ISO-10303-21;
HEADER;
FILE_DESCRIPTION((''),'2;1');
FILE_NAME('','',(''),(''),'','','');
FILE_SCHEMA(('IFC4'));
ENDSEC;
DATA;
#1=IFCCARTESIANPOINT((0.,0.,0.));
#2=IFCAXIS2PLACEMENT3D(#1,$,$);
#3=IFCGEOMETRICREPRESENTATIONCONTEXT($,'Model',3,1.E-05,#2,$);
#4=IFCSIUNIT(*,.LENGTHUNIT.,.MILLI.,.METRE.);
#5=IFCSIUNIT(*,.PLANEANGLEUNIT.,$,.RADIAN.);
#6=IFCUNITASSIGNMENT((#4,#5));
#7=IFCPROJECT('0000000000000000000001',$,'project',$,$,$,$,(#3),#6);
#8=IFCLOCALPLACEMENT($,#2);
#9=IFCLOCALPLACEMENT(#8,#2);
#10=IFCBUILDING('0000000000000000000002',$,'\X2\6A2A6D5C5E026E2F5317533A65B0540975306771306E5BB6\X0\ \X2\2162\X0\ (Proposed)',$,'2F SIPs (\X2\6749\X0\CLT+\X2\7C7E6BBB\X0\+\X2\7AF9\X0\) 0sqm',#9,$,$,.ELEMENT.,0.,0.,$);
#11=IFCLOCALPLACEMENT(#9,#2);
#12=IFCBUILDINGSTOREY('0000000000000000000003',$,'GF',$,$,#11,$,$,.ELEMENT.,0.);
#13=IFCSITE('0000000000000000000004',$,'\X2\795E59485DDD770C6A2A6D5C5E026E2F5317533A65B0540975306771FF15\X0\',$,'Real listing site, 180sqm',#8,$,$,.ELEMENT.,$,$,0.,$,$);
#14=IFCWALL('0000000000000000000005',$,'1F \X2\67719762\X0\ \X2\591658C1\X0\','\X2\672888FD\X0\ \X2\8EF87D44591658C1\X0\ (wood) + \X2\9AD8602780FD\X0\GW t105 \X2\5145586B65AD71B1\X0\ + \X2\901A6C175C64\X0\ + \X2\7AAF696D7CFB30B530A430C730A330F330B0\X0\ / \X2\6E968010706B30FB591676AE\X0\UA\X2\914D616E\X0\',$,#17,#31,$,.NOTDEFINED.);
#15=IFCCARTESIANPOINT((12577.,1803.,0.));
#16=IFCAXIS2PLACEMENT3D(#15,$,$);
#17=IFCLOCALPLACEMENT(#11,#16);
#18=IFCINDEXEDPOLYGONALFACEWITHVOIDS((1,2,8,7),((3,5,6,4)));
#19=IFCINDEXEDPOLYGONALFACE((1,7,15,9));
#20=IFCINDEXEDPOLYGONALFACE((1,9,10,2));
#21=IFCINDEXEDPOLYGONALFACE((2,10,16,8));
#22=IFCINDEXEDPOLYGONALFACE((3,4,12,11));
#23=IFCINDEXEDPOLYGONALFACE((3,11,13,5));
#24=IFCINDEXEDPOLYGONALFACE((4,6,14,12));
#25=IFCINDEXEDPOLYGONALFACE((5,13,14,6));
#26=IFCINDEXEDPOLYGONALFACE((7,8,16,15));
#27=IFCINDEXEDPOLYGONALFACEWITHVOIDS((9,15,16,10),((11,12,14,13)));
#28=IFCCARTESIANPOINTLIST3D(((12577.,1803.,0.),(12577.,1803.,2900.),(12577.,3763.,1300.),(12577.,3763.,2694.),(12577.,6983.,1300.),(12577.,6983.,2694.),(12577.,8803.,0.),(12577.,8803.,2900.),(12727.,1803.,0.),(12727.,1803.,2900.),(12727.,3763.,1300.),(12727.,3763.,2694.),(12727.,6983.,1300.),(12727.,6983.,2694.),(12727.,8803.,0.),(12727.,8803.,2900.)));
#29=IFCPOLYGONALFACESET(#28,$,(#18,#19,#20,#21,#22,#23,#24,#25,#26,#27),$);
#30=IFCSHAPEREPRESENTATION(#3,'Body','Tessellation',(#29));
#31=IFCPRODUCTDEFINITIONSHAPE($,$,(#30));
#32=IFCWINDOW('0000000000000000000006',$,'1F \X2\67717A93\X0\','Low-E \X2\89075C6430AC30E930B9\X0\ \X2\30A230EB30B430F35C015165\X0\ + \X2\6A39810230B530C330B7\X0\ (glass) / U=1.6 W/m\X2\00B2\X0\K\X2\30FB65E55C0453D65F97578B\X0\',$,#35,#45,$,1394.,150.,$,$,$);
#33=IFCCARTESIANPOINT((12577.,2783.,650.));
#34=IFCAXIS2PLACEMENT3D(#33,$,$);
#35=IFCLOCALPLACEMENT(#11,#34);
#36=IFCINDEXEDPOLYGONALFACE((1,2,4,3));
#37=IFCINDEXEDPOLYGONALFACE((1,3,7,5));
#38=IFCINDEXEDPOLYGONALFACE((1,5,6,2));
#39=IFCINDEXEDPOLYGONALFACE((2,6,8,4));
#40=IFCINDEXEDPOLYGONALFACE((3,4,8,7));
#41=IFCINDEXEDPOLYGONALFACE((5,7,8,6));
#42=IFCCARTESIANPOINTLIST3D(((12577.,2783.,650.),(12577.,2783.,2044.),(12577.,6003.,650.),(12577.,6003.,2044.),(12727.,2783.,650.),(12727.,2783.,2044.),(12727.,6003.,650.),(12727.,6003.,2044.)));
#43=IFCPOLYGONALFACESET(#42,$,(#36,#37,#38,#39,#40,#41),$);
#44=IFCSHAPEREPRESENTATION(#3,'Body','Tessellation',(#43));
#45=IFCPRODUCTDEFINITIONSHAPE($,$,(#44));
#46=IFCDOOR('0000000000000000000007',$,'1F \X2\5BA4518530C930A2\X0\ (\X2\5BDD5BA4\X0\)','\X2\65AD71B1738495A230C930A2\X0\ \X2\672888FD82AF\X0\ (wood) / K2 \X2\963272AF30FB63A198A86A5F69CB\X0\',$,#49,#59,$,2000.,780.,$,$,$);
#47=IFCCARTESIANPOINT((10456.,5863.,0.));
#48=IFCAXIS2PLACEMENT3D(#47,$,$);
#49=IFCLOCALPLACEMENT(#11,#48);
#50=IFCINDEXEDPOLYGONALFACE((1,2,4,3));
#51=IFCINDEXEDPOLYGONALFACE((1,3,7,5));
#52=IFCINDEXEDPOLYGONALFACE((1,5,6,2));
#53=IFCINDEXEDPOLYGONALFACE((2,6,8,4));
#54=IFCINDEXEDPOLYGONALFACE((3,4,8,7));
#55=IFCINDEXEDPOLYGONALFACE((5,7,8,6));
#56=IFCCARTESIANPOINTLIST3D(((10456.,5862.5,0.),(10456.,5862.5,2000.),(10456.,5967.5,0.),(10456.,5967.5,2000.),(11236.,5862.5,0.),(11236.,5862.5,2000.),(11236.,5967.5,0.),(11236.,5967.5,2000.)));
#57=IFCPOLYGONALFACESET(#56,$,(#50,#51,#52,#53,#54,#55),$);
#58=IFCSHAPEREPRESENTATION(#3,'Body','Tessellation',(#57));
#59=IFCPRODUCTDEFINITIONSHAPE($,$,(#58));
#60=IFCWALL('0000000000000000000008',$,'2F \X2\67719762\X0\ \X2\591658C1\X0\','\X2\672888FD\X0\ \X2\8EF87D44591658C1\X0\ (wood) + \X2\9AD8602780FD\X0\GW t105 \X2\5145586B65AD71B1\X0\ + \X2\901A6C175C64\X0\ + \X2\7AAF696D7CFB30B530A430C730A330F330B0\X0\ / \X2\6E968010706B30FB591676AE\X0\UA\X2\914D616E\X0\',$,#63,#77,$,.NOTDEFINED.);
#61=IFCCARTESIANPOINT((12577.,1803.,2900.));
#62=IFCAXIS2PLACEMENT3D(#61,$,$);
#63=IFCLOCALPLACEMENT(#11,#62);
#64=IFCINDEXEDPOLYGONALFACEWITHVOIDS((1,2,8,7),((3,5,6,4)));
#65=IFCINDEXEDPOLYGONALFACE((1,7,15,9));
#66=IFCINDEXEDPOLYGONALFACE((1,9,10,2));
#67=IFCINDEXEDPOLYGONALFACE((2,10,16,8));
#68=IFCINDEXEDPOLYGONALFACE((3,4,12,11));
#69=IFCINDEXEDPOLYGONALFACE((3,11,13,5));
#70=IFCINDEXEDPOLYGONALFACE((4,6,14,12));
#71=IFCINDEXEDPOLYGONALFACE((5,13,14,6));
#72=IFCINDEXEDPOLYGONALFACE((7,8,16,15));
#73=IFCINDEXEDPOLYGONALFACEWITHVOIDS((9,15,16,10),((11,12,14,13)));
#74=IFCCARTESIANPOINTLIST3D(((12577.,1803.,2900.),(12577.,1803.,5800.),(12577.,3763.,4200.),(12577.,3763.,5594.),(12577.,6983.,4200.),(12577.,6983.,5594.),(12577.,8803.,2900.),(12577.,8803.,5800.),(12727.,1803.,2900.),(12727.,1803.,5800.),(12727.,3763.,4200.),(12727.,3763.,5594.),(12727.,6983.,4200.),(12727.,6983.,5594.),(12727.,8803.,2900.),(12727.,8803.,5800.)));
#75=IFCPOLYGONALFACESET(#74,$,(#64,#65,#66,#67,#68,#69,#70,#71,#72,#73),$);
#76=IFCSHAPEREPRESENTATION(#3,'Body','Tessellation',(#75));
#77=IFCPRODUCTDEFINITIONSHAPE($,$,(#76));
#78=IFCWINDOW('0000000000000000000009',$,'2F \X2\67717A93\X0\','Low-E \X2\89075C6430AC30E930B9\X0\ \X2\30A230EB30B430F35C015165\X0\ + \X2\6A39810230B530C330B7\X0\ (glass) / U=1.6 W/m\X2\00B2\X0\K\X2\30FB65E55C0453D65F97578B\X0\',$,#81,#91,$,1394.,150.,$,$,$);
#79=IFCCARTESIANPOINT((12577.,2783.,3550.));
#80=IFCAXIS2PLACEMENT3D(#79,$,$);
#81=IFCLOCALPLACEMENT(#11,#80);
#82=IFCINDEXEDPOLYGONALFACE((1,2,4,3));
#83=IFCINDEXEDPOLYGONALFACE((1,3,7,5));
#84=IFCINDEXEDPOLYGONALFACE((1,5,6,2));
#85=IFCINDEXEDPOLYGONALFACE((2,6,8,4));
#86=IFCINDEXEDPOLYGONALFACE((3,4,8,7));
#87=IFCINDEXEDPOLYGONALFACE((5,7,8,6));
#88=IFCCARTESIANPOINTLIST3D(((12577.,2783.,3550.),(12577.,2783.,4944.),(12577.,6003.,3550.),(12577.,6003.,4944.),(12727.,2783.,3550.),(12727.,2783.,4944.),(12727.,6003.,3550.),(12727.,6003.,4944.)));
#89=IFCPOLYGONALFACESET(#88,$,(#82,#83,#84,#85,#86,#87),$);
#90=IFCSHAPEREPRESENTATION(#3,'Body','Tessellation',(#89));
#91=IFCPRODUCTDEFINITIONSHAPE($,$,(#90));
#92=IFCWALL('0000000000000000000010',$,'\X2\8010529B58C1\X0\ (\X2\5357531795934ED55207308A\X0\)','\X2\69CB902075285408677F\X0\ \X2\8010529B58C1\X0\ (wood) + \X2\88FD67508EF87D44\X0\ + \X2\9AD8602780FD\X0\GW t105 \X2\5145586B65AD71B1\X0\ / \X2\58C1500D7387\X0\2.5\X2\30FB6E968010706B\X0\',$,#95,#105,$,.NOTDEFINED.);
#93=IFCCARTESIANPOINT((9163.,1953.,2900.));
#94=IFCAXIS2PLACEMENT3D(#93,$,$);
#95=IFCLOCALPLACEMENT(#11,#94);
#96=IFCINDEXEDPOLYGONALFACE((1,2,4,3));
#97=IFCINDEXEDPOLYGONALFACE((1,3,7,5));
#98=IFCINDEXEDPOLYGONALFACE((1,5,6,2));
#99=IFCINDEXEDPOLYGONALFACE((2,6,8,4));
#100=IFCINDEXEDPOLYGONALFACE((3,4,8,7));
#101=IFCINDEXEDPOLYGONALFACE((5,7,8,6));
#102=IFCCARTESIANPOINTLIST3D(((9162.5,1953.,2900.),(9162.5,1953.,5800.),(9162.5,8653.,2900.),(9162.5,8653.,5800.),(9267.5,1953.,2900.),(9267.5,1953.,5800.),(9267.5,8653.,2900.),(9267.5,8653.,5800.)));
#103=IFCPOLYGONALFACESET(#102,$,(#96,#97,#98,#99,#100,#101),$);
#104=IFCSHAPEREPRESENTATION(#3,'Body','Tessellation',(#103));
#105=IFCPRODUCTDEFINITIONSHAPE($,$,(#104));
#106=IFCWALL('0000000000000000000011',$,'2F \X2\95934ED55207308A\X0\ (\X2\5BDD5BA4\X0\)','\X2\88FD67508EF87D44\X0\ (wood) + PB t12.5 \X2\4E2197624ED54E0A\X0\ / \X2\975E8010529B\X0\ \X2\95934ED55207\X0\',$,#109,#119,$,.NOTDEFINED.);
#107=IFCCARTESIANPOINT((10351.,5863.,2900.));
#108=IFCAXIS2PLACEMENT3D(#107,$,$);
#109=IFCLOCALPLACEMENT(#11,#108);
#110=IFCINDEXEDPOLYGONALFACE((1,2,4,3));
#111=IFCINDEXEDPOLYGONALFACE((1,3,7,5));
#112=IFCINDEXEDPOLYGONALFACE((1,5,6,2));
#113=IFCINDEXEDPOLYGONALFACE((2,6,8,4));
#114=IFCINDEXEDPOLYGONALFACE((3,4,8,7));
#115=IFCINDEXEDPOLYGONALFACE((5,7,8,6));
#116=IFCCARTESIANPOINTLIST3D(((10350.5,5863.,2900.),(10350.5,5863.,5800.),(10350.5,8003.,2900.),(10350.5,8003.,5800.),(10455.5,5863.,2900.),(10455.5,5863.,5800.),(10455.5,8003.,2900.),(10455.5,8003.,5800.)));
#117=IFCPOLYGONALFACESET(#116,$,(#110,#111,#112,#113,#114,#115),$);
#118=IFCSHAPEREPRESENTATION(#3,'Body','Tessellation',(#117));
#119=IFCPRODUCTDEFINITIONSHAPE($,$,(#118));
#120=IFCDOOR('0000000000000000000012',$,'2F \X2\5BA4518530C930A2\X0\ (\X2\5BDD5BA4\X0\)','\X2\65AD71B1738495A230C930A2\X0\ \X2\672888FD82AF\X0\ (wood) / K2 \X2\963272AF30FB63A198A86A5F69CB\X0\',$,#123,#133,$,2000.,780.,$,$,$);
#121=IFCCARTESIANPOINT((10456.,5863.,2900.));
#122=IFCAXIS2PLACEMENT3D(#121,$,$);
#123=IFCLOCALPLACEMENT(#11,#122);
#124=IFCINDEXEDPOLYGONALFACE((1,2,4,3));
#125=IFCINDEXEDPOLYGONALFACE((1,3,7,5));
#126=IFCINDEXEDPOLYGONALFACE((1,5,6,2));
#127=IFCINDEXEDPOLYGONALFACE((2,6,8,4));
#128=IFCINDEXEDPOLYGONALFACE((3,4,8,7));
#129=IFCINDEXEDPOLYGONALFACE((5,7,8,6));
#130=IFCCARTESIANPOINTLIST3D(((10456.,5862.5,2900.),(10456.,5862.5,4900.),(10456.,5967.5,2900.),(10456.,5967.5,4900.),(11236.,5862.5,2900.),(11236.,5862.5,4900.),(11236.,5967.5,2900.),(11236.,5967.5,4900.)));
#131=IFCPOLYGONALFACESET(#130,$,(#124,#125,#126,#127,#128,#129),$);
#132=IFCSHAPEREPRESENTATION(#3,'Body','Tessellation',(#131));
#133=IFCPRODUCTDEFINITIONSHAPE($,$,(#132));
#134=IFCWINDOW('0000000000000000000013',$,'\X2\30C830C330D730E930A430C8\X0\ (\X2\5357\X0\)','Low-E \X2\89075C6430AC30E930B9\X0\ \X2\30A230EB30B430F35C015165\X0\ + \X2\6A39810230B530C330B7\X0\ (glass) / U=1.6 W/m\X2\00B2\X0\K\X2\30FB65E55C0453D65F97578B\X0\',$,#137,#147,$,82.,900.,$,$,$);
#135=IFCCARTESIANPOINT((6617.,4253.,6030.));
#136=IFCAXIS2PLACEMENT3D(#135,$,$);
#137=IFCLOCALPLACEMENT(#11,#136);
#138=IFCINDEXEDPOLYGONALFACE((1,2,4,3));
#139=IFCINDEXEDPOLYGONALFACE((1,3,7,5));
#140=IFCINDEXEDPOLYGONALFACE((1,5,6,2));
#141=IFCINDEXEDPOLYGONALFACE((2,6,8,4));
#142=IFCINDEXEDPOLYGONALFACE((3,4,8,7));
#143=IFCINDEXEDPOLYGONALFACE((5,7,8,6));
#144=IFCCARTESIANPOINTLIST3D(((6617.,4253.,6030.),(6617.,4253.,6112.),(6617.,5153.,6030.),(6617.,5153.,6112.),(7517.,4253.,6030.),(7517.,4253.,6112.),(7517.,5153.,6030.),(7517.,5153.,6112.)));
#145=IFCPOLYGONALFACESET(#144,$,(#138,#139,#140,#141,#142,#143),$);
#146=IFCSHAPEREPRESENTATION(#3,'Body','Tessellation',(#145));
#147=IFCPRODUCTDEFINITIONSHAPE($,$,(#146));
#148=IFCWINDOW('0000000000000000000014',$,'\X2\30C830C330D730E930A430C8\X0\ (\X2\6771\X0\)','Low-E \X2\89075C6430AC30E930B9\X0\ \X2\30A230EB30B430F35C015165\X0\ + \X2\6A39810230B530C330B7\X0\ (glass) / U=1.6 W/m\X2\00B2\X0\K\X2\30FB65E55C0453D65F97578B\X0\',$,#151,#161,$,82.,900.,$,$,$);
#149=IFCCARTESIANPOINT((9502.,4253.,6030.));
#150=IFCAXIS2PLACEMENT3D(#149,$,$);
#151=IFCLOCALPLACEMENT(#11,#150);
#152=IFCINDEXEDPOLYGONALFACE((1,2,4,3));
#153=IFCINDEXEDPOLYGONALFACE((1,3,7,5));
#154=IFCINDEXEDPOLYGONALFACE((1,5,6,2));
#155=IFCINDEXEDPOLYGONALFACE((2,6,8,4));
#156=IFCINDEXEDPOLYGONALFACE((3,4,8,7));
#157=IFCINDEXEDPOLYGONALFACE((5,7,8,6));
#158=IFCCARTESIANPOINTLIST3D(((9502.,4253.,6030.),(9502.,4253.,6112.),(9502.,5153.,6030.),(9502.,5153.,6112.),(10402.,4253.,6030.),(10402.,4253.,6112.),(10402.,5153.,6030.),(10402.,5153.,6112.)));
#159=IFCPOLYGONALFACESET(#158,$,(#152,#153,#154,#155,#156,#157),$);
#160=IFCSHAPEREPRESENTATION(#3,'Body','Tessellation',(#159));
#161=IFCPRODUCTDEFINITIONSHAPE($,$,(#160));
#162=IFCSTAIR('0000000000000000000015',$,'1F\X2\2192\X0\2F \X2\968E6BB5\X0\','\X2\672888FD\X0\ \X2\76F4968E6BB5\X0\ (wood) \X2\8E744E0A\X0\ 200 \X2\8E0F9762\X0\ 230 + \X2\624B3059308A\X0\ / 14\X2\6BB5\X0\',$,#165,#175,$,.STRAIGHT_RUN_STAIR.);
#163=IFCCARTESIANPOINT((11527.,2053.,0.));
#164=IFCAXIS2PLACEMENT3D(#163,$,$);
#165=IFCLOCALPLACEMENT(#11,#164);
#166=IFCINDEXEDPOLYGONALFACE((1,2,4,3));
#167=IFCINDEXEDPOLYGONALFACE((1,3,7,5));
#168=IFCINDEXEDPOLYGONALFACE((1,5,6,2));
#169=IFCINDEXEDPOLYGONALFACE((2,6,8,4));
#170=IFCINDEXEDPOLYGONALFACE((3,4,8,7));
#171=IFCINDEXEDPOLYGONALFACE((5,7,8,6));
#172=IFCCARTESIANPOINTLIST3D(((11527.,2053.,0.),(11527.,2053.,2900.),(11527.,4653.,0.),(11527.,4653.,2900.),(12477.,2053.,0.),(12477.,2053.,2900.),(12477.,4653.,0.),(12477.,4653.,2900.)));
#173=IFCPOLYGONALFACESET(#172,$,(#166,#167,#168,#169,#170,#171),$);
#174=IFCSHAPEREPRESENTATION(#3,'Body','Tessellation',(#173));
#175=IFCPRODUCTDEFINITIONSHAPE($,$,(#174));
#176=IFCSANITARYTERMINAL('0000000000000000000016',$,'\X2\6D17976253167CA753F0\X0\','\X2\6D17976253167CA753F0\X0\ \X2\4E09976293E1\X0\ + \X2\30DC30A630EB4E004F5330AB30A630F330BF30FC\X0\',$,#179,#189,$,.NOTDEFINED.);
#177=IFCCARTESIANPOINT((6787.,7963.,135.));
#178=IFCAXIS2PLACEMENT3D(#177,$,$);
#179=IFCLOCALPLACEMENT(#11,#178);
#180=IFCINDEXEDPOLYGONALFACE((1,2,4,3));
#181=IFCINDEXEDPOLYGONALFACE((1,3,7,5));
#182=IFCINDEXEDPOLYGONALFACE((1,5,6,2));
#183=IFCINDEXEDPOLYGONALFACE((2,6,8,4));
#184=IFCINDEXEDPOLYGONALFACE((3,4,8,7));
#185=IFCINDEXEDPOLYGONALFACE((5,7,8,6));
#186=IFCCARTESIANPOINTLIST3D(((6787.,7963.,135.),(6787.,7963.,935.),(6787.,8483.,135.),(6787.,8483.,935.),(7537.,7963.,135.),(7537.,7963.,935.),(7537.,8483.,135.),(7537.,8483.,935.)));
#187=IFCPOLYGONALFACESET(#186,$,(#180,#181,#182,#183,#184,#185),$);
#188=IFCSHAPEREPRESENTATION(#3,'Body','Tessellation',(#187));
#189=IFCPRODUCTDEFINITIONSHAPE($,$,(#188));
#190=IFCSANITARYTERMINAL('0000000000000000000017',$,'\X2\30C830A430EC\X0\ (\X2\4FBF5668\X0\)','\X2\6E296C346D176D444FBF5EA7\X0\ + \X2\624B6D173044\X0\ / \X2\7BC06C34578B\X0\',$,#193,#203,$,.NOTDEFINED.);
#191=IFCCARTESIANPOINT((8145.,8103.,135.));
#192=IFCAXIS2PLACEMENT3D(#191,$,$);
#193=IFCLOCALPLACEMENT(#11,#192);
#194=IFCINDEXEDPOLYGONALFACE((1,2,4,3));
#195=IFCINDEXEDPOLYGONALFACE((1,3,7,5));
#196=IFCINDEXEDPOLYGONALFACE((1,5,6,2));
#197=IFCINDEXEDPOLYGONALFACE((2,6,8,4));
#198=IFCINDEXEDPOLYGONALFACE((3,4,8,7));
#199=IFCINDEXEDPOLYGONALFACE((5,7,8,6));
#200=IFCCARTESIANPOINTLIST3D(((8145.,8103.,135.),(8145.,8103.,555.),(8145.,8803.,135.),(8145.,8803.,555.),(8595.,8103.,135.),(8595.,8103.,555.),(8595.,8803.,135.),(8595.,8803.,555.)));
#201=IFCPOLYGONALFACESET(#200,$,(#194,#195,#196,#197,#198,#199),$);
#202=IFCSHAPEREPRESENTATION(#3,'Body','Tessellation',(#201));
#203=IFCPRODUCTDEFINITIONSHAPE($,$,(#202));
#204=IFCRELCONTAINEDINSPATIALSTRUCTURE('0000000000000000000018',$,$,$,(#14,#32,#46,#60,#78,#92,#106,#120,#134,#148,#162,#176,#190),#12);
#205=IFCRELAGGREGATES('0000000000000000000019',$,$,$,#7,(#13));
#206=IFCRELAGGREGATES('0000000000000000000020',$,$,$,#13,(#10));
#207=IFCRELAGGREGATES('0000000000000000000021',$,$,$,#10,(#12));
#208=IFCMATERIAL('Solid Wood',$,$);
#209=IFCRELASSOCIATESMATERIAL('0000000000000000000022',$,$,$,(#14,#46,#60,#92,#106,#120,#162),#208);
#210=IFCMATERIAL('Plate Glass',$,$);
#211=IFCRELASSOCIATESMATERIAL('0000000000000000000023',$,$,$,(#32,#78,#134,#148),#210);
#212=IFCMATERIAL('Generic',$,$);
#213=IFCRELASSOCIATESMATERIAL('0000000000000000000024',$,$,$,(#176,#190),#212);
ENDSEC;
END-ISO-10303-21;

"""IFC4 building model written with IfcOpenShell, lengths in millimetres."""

from ifc_helpers import new_model, si_unit, frame, frame_2d, origin, place, context, project, spatial, rectangle, extrude, material, element, fill, save


model = new_model("IFC4")

# Units and contexts
model_context = context("Model", 3, precision=1e-05, world=origin())
ifc_project = project(units=[si_unit("LENGTHUNIT", "METRE", prefix="MILLI"), si_unit("PLANEANGLEUNIT", "RADIAN")], contexts=[model_context])

# Site, building, storey
site_placement = place(None, origin())
site = spatial("IfcSite", under=ifc_project, at=site_placement, Name="神奈川県横浜市港北区新吉田東５", ObjectType="Real listing site, 180sqm", CompositionType="ELEMENT", RefElevation=0.0)
building_placement = place(site_placement, origin())
building = spatial("IfcBuilding", under=site, at=building_placement, Name="横浜市港北区新吉田東の家 Ⅲ (Proposed)", ObjectType="2F SIPs (杉CLT+籾殻+竹) 0sqm", CompositionType="ELEMENT", ElevationOfRefHeight=0.0, ElevationOfTerrain=0.0)
storey_placement = place(building_placement, origin())
storey = spatial("IfcBuildingStorey", under=building, at=storey_placement, Name="GF", CompositionType="ELEMENT", Elevation=0.0)

# Wall, opening, window
ifc_material_1 = material(Name="Solid Wood")
wall_1_placement = place(storey_placement, frame((12577.0, 1803.0, 0.0)))
wall_1 = element("IfcWall", 1, at=wall_1_placement, inside=storey, material=ifc_material_1, Name="1F 東面 外壁", Description="木製 軸組外壁 (wood) + 高性能GW t105 充填断熱 + 通気層 + 窯業系サイディング / 準耐火・外皮UA配慮", PredefinedType="NOTDEFINED", context=model_context, shape_type="SweptSolid", body=[
    extrude(rectangle(XDim=150.0, YDim=7000.0, at=frame_2d((75.0, 3500.0))), frame((12577.0, 1803.0, 0.0)), (0.0, 0.0, 1.0), 2900.0),
])
opening_1_placement = place(storey_placement, frame((12577.0, 2783.0, 650.0)))
opening_1 = element("IfcOpeningElement", 2, at=opening_1_placement, cuts=wall_1, PredefinedType="NOTDEFINED", context=model_context, shape_type="SweptSolid", body=[
    extrude(rectangle(XDim=150.0, YDim=3220.0, at=frame_2d((75.0, 1610.0))), frame((12577.0, 2783.0, 650.0)), (0.0, 0.0, 1.0), 1394.0),
])
ifc_material_2 = material(Name="Plate Glass")
window_1_placement = place(storey_placement, frame((12577.0, 2783.0, 650.0)))
window_1 = element("IfcWindow", 3, at=window_1_placement, inside=storey, material=ifc_material_2, Name="1F 東窓", Description="Low-E 複層ガラス アルゴン封入 + 樹脂サッシ (glass) / U=1.6 W/m²K・日射取得型", OverallHeight=1394.0, OverallWidth=150.0, context=model_context, shape_type="SweptSolid", body=[
    extrude(rectangle(XDim=150.0, YDim=3220.0, at=frame_2d((75.0, 1610.0))), frame((12577.0, 2783.0, 650.0)), (0.0, 0.0, 1.0), 1394.0),
])
fill(opening_1, window_1)

# Door
door_1_placement = place(storey_placement, frame((10456.0, 5863.0, 0.0)))
element("IfcDoor", 4, at=door_1_placement, inside=storey, material=ifc_material_1, Name="1F 室内ドア (寝室)", Description="断熱玄関ドア 木製芯 (wood) / K2 防犯・採風機構", OverallHeight=2000.0, OverallWidth=780.0, context=model_context, shape_type="SweptSolid", body=[
    extrude(rectangle(XDim=780.0, YDim=105.0, at=frame_2d((390.0, 52.0))), frame((10456.0, 5863.0, 0.0)), (0.0, 0.0, 1.0), 2000.0),
])

# Wall, opening, window
wall_2_placement = place(storey_placement, frame((12577.0, 1803.0, 2900.0)))
wall_2 = element("IfcWall", 5, at=wall_2_placement, inside=storey, material=ifc_material_1, Name="2F 東面 外壁", Description="木製 軸組外壁 (wood) + 高性能GW t105 充填断熱 + 通気層 + 窯業系サイディング / 準耐火・外皮UA配慮", PredefinedType="NOTDEFINED", context=model_context, shape_type="SweptSolid", body=[
    extrude(rectangle(XDim=150.0, YDim=7000.0, at=frame_2d((75.0, 3500.0))), frame((12577.0, 1803.0, 2900.0)), (0.0, 0.0, 1.0), 2900.0),
])
opening_2_placement = place(storey_placement, frame((12577.0, 2783.0, 3550.0)))
opening_2 = element("IfcOpeningElement", 6, at=opening_2_placement, cuts=wall_2, PredefinedType="NOTDEFINED", context=model_context, shape_type="SweptSolid", body=[
    extrude(rectangle(XDim=150.0, YDim=3220.0, at=frame_2d((75.0, 1610.0))), frame((12577.0, 2783.0, 3550.0)), (0.0, 0.0, 1.0), 1394.0),
])
window_2_placement = place(storey_placement, frame((12577.0, 2783.0, 3550.0)))
window_2 = element("IfcWindow", 7, at=window_2_placement, inside=storey, material=ifc_material_2, Name="2F 東窓", Description="Low-E 複層ガラス アルゴン封入 + 樹脂サッシ (glass) / U=1.6 W/m²K・日射取得型", OverallHeight=1394.0, OverallWidth=150.0, context=model_context, shape_type="SweptSolid", body=[
    extrude(rectangle(XDim=150.0, YDim=3220.0, at=frame_2d((75.0, 1610.0))), frame((12577.0, 2783.0, 3550.0)), (0.0, 0.0, 1.0), 1394.0),
])
fill(opening_2, window_2)

# Walls
wall_3_placement = place(storey_placement, frame((9163.0, 1953.0, 2900.0)))
element("IfcWall", 8, at=wall_3_placement, inside=storey, material=ifc_material_1, Name="耐力壁 (南北間仕切り)", Description="構造用合板 耐力壁 (wood) + 製材軸組 + 高性能GW t105 充填断熱 / 壁倍率2.5・準耐火", PredefinedType="NOTDEFINED", context=model_context, shape_type="SweptSolid", body=[
    extrude(rectangle(XDim=105.0, YDim=6700.0, at=frame_2d((52.0, 3350.0))), frame((9163.0, 1953.0, 2900.0)), (0.0, 0.0, 1.0), 2900.0),
])
wall_4_placement = place(storey_placement, frame((10351.0, 5863.0, 2900.0)))
element("IfcWall", 9, at=wall_4_placement, inside=storey, material=ifc_material_1, Name="2F 間仕切り (寝室)", Description="製材軸組 (wood) + PB t12.5 両面仕上 / 非耐力 間仕切", PredefinedType="NOTDEFINED", context=model_context, shape_type="SweptSolid", body=[
    extrude(rectangle(XDim=105.0, YDim=2140.0, at=frame_2d((52.0, 1070.0))), frame((10351.0, 5863.0, 2900.0)), (0.0, 0.0, 1.0), 2900.0),
])

# Door
door_2_placement = place(storey_placement, frame((10456.0, 5863.0, 2900.0)))
element("IfcDoor", 10, at=door_2_placement, inside=storey, material=ifc_material_1, Name="2F 室内ドア (寝室)", Description="断熱玄関ドア 木製芯 (wood) / K2 防犯・採風機構", OverallHeight=2000.0, OverallWidth=780.0, context=model_context, shape_type="SweptSolid", body=[
    extrude(rectangle(XDim=780.0, YDim=105.0, at=frame_2d((390.0, 52.0))), frame((10456.0, 5863.0, 2900.0)), (0.0, 0.0, 1.0), 2000.0),
])

# Windows
window_3_placement = place(storey_placement, frame((6617.0, 4253.0, 6030.0)))
element("IfcWindow", 11, at=window_3_placement, inside=storey, material=ifc_material_2, Name="トップライト (南)", Description="Low-E 複層ガラス アルゴン封入 + 樹脂サッシ (glass) / U=1.6 W/m²K・日射取得型", OverallHeight=82.0, OverallWidth=900.0, context=model_context, shape_type="SweptSolid", body=[
    extrude(rectangle(XDim=900.0, YDim=900.0, at=frame_2d((450.0, 450.0))), frame((6617.0, 4253.0, 6030.0)), (0.0, 0.0, 1.0), 82.0),
])
window_4_placement = place(storey_placement, frame((9502.0, 4253.0, 6030.0)))
element("IfcWindow", 12, at=window_4_placement, inside=storey, material=ifc_material_2, Name="トップライト (東)", Description="Low-E 複層ガラス アルゴン封入 + 樹脂サッシ (glass) / U=1.6 W/m²K・日射取得型", OverallHeight=82.0, OverallWidth=900.0, context=model_context, shape_type="SweptSolid", body=[
    extrude(rectangle(XDim=900.0, YDim=900.0, at=frame_2d((450.0, 450.0))), frame((9502.0, 4253.0, 6030.0)), (0.0, 0.0, 1.0), 82.0),
])

# Stair
stair_placement = place(storey_placement, frame((11527.0, 2053.0, 0.0)))
element("IfcStair", 13, at=stair_placement, inside=storey, material=ifc_material_1, Name="1F→2F 階段", Description="木製 直階段 (wood) 蹴上 200 踏面 230 + 手すり / 14段", PredefinedType="STRAIGHT_RUN_STAIR", context=model_context, shape_type="SweptSolid", body=[
    extrude(rectangle(XDim=950.0, YDim=2600.0, at=frame_2d((475.0, 1300.0))), frame((11527.0, 2053.0, 0.0)), (0.0, 0.0, 1.0), 2900.0),
])

# Sanitary terminals
ifc_material_3 = material(Name="Generic")
sanitary_terminal_1_placement = place(storey_placement, frame((6787.0, 7963.0, 135.0)))
element("IfcSanitaryTerminal", 14, at=sanitary_terminal_1_placement, inside=storey, material=ifc_material_3, Name="洗面化粧台", Description="洗面化粧台 三面鏡 + ボウル一体カウンター", PredefinedType="NOTDEFINED", context=model_context, shape_type="SweptSolid", body=[
    extrude(rectangle(XDim=750.0, YDim=520.0, at=frame_2d((375.0, 260.0))), frame((6787.0, 7963.0, 135.0)), (0.0, 0.0, 1.0), 800.0),
])
sanitary_terminal_2_placement = place(storey_placement, frame((8145.0, 8103.0, 135.0)))
element("IfcSanitaryTerminal", 15, at=sanitary_terminal_2_placement, inside=storey, material=ifc_material_3, Name="トイレ (便器)", Description="温水洗浄便座 + 手洗い / 節水型", PredefinedType="NOTDEFINED", context=model_context, shape_type="SweptSolid", body=[
    extrude(rectangle(XDim=450.0, YDim=700.0, at=frame_2d((225.0, 350.0))), frame((8145.0, 8103.0, 135.0)), (0.0, 0.0, 1.0), 420.0),
])

save(model, "model.ifc")
